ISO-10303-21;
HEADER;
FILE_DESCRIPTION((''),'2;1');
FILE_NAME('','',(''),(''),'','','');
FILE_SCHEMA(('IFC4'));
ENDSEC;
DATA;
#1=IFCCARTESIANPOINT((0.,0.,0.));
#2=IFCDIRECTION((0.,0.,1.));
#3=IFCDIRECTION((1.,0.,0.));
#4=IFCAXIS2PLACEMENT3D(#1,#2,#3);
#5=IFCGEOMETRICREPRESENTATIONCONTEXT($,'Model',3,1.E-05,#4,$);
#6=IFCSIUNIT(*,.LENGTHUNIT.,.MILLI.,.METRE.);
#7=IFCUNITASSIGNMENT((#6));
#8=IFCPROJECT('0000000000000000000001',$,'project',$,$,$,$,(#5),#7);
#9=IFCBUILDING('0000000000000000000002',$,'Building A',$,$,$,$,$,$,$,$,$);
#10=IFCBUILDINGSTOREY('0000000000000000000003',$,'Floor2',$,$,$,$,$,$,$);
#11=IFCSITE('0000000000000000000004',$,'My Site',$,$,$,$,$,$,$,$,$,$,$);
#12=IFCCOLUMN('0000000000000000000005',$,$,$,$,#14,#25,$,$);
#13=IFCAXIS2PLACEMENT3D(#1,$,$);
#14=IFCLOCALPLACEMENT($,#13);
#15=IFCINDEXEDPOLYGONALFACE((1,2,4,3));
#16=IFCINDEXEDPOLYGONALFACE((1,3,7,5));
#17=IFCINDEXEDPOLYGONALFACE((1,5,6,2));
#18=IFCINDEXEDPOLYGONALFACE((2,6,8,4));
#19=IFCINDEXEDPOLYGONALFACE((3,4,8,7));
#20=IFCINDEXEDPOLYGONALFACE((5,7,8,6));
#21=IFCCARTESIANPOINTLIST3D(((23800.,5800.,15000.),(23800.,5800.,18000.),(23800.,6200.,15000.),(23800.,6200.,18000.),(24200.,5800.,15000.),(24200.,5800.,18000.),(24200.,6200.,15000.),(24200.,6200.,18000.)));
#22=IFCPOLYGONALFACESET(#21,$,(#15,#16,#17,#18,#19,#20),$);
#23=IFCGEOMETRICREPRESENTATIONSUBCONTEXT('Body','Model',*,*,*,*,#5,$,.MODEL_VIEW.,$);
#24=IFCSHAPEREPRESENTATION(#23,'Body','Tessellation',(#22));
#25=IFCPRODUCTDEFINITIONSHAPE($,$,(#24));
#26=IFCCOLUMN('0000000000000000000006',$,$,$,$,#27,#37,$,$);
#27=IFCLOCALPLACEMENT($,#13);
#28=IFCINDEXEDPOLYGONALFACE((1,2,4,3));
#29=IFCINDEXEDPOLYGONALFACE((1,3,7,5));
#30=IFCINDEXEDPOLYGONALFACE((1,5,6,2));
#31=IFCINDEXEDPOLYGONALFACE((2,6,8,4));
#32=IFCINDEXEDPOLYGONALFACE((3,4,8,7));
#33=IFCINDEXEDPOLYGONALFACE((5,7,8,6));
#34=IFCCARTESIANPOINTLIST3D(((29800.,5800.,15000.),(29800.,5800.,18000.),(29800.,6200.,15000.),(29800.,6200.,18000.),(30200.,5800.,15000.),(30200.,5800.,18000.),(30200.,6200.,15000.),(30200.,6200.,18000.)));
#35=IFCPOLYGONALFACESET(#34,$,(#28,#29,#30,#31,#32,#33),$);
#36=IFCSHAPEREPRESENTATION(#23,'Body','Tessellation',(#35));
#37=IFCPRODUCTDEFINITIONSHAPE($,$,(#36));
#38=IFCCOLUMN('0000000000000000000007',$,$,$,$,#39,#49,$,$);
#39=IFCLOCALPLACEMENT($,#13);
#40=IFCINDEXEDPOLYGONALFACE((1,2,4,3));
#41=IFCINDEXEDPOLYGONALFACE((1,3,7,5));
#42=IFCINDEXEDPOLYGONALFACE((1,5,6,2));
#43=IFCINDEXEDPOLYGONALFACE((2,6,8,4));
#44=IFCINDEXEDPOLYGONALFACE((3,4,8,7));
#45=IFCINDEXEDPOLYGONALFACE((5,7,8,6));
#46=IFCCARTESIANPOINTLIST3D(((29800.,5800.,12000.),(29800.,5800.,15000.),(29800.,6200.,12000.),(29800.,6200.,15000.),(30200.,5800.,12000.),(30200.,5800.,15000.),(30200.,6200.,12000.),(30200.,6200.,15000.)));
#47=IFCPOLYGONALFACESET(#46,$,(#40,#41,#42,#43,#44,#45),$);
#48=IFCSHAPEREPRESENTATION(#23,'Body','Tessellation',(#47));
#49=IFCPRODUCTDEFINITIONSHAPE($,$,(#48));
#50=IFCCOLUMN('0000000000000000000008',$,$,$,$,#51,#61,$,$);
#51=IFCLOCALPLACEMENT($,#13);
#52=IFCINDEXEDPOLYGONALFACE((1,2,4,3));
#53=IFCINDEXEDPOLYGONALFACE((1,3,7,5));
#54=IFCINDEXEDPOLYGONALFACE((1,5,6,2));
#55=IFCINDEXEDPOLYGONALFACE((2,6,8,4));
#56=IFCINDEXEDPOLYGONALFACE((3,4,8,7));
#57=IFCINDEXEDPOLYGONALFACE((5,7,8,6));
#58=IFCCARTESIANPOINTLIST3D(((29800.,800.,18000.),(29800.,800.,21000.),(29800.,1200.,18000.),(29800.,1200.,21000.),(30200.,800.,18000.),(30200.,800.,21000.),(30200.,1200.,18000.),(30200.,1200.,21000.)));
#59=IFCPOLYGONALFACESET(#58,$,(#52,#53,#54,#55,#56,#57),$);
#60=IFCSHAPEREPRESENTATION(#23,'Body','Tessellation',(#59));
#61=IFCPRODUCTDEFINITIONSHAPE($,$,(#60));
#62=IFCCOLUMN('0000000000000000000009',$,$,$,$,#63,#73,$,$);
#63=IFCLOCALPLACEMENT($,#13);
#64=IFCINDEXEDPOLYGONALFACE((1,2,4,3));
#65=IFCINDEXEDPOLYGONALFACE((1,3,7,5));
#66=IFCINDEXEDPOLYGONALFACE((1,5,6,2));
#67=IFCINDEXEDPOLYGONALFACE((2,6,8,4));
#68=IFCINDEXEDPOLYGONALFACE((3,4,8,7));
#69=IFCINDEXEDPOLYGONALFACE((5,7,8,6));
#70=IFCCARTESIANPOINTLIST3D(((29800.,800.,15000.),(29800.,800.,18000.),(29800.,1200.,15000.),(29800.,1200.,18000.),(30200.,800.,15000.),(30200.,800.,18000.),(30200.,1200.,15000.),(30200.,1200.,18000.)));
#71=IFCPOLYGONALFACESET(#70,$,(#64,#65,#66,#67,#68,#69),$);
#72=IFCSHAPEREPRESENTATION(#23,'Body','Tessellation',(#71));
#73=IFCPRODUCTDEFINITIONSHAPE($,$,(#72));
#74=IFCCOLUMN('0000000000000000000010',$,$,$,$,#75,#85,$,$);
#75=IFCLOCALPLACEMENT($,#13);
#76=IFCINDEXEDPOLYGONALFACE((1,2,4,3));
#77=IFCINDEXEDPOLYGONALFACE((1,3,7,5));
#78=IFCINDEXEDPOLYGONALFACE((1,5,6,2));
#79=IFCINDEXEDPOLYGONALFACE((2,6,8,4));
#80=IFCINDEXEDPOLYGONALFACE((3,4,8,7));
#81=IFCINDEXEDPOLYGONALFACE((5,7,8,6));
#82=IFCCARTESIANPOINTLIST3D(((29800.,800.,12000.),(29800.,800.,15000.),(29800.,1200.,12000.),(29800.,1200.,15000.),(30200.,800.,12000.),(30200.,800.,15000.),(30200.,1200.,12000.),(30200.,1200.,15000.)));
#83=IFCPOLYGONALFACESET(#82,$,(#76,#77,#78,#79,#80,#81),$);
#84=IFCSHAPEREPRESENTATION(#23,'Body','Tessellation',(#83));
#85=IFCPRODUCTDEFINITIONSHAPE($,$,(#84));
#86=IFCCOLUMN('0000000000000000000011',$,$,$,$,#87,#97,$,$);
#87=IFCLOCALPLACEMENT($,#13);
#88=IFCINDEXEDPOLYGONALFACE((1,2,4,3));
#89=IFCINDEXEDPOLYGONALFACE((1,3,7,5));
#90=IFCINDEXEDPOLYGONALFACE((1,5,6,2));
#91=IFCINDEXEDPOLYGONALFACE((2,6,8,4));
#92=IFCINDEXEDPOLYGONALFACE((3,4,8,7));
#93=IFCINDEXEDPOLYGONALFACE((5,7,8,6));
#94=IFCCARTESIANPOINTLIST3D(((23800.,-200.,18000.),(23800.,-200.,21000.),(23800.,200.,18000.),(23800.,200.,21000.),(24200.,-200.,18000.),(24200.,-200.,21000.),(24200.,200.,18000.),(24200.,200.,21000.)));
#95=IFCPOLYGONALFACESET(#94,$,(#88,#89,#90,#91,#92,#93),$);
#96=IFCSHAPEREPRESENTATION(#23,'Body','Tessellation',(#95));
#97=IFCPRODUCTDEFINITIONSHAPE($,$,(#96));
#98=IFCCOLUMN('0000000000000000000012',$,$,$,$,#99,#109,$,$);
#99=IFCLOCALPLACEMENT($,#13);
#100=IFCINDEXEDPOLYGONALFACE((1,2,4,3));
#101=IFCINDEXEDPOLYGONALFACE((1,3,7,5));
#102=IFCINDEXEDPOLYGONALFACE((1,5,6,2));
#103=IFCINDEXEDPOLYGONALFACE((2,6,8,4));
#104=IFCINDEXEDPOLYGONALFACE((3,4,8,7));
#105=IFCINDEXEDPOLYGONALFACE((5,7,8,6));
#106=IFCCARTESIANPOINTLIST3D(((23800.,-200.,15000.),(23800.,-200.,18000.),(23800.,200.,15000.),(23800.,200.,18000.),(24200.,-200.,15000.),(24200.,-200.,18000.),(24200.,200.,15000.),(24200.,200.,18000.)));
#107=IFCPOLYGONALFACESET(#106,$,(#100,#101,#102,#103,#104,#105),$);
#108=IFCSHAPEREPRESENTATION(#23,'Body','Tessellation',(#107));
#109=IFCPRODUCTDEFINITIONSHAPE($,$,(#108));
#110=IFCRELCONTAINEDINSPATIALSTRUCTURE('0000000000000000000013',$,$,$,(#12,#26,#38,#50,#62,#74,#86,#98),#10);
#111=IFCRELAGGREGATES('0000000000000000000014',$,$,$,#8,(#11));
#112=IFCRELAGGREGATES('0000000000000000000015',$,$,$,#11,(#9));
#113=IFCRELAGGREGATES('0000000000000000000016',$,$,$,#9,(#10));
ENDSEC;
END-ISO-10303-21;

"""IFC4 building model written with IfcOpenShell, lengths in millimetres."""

from ifc_helpers import new_model, si_unit, frame, origin_with_axes, place, context, subcontext, project, spatial, line, indexed_curve, outline, extrude, element, save


model = new_model("IFC4")

# Units and contexts
model_context = context("Model", 3, precision=1e-05, world=origin_with_axes())
body_context = subcontext(model_context, "Body", "Model", "MODEL_VIEW")
ifc_project = project(units=[si_unit("LENGTHUNIT", "METRE", prefix="MILLI")], contexts=[model_context])

# Site, building, storey
site = spatial("IfcSite", under=ifc_project, Name="My Site")
building = spatial("IfcBuilding", under=site, Name="Building A")
storey = spatial("IfcBuildingStorey", under=building, Name="Floor2")

# Columns
for number, where, z_axis, x_axis in (
    (1, (24000.0, 6000.0, 15000.0), (0.0, 0.0, 1.0), (1.0, 0.0, 0.0)),
    (2, (30000.0, 6000.0, 15000.0), (0.0, 0.0, 1.0), (1.0, 0.0, 0.0)),
    (3, (30000.0, 6000.0, 12000.0), (0.0, 0.0, 1.0), (1.0, 0.0, 0.0)),
    (4, (30000.0, 1000.0, 18000.0), (0.0, 0.0, 1.0), (1.0, 0.0, 0.0)),
    (5, (30000.0, 1000.0, 15000.0), (0.0, 0.0, 1.0), (1.0, 0.0, 0.0)),
    (6, (30000.0, 1000.0, 12000.0), (0.0, 0.0, 1.0), (1.0, 0.0, 0.0)),
    (7, (24000.0, 0.0, 18000.0), (0.0, 0.0, 1.0), (1.0, 0.0, 0.0)),
    (8, (24000.0, 0.0, 15000.0), (0.0, 0.0, 1.0), (1.0, 0.0, 0.0)),
):
    element("IfcColumn", number, at=place(None, frame(where, z_axis=z_axis, x_axis=x_axis)), inside=storey, context=body_context, shape_type="SweptSolid", body=[
        extrude(outline(indexed_curve([(-200.0, -200.0), (200.0, -200.0), (200.0, 200.0), (-200.0, 200.0)], segments=[line(1, 2, 3, 4, 1)])), origin_with_axes(), (0.0, 0.0, 1.0), 3000.0),
    ])

save(model, "model.ifc")
